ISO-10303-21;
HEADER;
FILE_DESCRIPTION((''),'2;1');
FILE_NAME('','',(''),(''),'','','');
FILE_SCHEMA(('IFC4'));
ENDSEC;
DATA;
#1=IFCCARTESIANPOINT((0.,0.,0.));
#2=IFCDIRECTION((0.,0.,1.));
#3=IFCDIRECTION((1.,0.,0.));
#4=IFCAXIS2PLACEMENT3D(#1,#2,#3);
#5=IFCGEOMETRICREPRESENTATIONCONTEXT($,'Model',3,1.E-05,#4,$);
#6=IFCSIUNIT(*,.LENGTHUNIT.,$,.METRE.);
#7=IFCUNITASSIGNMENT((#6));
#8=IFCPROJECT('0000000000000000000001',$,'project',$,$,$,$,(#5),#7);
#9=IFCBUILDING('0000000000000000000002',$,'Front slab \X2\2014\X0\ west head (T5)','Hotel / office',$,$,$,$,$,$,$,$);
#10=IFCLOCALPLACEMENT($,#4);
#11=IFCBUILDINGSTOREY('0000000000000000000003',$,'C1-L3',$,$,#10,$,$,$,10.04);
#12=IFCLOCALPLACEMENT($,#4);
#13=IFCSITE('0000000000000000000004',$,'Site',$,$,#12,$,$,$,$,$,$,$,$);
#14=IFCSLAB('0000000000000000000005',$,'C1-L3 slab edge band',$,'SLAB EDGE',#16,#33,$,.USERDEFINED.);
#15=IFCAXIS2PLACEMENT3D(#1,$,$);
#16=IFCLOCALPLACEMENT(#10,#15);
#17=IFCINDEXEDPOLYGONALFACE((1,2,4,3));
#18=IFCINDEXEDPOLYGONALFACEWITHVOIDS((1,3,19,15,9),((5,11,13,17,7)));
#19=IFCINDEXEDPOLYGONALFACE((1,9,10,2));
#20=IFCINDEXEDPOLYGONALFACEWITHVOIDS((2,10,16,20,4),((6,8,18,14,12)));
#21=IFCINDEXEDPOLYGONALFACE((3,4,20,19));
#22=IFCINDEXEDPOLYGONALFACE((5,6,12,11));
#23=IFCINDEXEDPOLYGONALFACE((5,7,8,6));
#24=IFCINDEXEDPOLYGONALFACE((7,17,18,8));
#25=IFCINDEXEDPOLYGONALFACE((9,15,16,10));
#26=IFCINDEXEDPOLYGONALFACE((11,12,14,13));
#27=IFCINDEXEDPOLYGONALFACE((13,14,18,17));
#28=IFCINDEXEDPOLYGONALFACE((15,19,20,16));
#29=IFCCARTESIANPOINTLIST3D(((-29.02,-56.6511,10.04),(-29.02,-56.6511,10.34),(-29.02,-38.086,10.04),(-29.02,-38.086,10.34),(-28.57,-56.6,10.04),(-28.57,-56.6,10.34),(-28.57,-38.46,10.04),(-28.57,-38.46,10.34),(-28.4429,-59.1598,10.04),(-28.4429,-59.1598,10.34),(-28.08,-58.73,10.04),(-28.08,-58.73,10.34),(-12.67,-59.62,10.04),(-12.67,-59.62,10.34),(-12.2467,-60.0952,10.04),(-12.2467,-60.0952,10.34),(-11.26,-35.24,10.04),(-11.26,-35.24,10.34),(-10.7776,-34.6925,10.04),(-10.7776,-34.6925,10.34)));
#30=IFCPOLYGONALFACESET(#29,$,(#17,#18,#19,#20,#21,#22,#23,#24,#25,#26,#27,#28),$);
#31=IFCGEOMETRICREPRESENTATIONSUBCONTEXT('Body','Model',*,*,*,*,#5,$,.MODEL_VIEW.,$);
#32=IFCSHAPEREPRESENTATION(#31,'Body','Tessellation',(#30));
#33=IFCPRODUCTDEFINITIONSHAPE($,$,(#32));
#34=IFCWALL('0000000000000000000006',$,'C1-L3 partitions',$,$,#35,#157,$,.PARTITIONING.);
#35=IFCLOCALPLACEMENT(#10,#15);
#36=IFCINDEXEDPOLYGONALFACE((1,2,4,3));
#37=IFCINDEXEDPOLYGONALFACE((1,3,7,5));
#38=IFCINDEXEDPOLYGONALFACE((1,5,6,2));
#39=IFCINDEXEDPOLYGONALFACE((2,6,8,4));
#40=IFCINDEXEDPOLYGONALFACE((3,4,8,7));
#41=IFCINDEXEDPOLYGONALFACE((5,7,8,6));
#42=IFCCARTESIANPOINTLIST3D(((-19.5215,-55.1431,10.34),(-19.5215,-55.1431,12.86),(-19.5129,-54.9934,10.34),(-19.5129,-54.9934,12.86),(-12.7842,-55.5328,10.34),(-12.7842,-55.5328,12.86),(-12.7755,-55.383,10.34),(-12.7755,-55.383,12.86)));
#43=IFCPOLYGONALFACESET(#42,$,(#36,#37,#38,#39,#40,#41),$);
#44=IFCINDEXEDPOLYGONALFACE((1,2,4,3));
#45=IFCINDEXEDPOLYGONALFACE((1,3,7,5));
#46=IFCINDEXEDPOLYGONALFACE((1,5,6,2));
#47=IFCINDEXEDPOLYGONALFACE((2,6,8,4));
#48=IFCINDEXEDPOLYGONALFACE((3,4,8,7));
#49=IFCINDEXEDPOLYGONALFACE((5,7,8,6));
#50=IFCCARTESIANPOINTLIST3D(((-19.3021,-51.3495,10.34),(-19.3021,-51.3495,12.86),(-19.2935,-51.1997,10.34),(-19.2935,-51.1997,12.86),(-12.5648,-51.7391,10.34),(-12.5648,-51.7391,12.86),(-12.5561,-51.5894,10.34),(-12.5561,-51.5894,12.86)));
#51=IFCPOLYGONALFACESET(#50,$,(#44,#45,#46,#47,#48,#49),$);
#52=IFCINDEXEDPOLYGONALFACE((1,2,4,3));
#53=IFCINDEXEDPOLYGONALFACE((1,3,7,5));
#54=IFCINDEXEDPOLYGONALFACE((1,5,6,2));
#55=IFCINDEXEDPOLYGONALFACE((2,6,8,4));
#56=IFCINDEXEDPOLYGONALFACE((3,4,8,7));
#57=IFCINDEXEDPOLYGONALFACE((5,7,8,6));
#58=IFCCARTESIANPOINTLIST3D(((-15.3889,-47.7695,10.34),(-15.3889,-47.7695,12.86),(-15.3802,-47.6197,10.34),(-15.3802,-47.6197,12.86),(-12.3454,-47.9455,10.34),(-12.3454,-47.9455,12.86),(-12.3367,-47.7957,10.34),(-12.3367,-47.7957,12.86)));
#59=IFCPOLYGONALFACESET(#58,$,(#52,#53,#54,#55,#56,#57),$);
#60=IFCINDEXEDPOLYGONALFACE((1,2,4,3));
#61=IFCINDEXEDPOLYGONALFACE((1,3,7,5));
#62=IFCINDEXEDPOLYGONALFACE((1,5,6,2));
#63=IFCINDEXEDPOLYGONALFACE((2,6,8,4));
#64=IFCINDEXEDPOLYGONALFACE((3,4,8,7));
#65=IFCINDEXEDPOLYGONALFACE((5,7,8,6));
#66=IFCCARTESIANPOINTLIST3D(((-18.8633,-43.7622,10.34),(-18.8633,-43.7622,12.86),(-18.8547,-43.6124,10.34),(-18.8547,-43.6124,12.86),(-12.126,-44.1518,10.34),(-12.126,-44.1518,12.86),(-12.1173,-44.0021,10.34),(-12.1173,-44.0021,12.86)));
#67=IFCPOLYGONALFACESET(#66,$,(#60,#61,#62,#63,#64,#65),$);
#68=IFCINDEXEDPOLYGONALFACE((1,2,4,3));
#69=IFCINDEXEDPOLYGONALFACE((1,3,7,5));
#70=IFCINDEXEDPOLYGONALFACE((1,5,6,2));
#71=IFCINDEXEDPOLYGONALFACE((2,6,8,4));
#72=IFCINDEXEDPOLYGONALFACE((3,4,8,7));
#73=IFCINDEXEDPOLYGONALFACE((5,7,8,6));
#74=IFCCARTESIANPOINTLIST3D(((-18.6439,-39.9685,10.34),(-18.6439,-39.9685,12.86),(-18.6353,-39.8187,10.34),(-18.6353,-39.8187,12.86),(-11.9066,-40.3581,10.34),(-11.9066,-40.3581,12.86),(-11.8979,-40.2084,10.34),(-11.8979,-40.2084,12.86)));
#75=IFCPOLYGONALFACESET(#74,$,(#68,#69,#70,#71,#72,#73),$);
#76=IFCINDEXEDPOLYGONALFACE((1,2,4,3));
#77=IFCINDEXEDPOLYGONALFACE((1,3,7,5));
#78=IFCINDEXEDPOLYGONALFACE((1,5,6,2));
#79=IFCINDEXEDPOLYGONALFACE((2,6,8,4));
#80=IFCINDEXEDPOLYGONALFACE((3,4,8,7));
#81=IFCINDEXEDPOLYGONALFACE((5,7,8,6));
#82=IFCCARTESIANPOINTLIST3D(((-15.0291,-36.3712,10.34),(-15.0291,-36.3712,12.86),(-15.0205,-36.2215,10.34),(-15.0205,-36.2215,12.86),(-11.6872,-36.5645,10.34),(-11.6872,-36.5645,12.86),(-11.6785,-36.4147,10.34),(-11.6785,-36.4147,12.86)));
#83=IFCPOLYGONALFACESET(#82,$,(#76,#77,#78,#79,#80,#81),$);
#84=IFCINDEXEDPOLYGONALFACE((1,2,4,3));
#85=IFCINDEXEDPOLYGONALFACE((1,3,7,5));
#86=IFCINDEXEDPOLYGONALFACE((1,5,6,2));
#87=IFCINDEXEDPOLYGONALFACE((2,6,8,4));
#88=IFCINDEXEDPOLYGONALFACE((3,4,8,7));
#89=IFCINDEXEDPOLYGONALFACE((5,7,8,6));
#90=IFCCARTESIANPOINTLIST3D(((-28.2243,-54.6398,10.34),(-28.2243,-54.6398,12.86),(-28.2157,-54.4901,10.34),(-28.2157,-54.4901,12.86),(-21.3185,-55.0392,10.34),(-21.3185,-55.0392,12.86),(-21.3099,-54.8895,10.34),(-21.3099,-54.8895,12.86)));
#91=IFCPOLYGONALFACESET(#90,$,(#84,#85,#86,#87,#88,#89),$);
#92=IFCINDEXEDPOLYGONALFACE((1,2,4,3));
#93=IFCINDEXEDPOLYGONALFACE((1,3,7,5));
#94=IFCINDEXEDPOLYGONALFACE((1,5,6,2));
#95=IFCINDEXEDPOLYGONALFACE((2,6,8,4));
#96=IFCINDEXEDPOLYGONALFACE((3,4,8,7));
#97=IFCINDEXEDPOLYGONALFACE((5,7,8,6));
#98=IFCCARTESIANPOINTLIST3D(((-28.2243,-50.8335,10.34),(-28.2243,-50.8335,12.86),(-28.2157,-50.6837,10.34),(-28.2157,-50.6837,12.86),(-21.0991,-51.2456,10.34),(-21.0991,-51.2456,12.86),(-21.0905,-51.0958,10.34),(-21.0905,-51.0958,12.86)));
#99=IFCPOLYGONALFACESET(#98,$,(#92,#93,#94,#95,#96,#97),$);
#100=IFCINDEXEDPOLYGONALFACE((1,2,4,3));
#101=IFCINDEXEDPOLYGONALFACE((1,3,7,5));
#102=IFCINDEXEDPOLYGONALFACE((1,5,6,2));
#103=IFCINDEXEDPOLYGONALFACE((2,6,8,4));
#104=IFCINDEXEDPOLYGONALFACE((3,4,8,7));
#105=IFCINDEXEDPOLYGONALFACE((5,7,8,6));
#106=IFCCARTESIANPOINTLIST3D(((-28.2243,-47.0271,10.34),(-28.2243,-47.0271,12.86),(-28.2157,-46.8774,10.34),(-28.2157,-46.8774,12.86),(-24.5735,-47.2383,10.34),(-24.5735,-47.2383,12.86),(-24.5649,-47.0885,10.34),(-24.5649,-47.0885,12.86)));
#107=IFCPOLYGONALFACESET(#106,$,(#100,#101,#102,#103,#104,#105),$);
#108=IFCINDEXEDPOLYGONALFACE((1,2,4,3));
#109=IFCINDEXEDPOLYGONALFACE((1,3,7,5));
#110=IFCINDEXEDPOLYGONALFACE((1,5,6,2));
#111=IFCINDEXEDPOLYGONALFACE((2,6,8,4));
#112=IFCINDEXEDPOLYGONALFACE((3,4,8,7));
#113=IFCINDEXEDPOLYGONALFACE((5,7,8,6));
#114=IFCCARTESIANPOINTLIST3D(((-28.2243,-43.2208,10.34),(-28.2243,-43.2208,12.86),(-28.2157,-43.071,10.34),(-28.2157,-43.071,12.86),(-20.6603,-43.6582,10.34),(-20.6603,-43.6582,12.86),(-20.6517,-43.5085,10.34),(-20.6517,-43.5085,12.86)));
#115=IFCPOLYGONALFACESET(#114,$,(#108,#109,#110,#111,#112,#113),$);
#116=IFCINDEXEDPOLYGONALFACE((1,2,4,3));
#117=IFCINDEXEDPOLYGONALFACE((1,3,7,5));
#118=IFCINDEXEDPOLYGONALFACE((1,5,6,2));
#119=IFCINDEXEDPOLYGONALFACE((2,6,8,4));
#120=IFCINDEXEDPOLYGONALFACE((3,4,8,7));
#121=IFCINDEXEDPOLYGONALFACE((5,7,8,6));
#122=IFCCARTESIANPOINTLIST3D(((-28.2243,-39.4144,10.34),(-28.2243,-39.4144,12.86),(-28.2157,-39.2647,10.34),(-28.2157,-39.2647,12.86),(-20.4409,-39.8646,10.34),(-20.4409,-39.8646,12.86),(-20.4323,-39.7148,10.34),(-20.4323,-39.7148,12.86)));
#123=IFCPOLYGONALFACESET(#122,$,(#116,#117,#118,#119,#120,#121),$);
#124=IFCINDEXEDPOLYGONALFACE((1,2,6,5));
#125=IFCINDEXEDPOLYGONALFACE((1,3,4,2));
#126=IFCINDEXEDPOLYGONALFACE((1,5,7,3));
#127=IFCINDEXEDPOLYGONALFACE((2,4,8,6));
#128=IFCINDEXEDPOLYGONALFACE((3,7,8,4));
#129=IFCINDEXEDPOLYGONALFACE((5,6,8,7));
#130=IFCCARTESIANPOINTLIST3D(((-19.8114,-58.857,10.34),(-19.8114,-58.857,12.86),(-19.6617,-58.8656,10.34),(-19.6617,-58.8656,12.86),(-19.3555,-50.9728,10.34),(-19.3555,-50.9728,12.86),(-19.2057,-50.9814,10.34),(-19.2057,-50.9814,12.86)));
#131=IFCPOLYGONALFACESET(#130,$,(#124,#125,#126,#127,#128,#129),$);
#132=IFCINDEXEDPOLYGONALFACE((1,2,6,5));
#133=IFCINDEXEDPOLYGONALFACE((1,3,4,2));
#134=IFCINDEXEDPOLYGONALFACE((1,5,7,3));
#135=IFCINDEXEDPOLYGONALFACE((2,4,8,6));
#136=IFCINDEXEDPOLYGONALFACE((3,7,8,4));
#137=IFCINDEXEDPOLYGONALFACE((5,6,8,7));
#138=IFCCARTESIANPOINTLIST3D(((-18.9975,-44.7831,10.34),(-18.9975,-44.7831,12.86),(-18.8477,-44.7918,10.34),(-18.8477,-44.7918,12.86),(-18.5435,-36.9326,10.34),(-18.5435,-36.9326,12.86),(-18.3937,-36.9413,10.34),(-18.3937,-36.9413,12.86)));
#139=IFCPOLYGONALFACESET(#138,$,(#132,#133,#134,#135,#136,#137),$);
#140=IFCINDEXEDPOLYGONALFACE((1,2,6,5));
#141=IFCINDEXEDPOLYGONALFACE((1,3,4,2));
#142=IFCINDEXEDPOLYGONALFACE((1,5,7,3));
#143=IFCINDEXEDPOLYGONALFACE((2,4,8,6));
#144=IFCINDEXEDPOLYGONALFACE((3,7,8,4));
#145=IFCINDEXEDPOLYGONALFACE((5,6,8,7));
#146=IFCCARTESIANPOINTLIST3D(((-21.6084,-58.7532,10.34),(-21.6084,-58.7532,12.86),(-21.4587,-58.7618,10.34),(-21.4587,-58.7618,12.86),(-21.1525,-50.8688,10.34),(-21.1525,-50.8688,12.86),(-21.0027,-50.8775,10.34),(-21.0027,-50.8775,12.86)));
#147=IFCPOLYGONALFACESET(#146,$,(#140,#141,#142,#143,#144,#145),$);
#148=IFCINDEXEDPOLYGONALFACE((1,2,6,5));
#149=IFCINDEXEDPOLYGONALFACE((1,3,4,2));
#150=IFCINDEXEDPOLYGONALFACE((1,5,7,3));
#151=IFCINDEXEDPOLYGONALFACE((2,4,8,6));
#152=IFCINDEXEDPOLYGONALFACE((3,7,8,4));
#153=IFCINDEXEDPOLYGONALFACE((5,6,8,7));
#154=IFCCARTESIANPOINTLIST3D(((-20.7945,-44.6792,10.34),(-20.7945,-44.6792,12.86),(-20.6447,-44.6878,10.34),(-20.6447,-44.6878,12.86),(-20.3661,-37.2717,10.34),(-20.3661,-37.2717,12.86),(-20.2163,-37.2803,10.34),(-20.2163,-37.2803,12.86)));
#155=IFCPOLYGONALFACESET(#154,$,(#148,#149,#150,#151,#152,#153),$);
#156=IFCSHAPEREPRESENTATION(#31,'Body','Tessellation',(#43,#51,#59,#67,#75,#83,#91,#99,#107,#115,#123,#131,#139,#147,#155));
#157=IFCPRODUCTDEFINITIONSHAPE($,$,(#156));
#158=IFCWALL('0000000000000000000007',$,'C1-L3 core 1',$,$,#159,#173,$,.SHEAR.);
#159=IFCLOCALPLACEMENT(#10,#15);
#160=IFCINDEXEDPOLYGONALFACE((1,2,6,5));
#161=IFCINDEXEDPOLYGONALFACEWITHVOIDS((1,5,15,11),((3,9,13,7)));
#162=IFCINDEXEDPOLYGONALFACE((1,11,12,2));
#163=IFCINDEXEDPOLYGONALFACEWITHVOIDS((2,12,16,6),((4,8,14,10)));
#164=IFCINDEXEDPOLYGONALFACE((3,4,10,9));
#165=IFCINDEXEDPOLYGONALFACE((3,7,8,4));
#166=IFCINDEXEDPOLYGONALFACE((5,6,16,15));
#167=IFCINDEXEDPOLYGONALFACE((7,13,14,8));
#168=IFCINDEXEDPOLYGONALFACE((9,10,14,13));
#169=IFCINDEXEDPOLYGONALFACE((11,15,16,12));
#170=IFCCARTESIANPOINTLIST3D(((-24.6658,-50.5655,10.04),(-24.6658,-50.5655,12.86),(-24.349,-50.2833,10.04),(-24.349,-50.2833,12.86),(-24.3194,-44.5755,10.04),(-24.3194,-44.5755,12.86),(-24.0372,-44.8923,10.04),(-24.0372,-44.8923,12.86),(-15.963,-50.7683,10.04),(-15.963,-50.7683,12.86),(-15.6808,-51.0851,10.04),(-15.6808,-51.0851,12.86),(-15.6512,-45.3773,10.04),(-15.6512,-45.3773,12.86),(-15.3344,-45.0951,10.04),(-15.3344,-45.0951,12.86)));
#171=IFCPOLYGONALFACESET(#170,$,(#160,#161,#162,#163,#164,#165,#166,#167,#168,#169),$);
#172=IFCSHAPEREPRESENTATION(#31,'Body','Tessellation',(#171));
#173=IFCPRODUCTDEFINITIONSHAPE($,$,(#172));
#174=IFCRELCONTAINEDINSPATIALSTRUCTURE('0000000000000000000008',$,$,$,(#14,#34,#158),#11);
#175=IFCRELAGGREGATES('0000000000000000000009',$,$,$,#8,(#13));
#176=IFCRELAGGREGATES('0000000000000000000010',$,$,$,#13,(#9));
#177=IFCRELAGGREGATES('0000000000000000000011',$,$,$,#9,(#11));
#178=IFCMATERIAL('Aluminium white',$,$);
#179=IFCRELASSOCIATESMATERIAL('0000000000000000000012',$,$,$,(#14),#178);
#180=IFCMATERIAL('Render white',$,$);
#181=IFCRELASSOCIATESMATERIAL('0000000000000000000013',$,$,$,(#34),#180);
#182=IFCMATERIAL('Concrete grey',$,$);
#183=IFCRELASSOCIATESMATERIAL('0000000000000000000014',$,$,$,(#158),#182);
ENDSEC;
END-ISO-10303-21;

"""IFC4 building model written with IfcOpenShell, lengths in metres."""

from ifc_helpers import new_model, si_unit, frame, origin_with_axes, place, context, subcontext, project, spatial, polyline, outline, extrude, material, element, save


model = new_model("IFC4")

# Units and contexts
model_context = context("Model", 3, precision=1e-05, world=origin_with_axes())
body_context = subcontext(model_context, "Body", "Model", "MODEL_VIEW")
ifc_project = project(units=[si_unit("LENGTHUNIT", "METRE")], contexts=[model_context])

# Site, building, storey
site_placement = place(None, origin_with_axes())
site = spatial("IfcSite", under=ifc_project, at=site_placement, Name="Site")
building = spatial("IfcBuilding", under=site, Name="Front slab — west head (T5)", Description="Hotel / office")
storey_placement = place(None, origin_with_axes())
storey = spatial("IfcBuildingStorey", under=building, at=storey_placement, Name="C1-L3", Elevation=10.04)

# Shared definitions
ifc_material_1 = material(Name="Aluminium white")

# Slab
slab_placement = place(storey_placement, origin_with_axes())
element("IfcSlab", 1, at=slab_placement, inside=storey, material=ifc_material_1, Name="C1-L3 slab edge band", ObjectType="SLAB EDGE", PredefinedType="USERDEFINED", context=body_context, shape_type="SweptSolid", body=[
    extrude(outline(polyline([(-10.7776, -34.6925), (-29.02, -38.086), (-29.02, -56.6511), (-28.4429, -59.1598), (-12.2467, -60.0952), (-10.7776, -34.6925)]), holes=[polyline([(-11.26, -35.24), (-28.57, -38.46), (-28.57, -56.6), (-28.08, -58.73), (-12.67, -59.62), (-11.26, -35.24)])]), frame((0.0, 0.0, 10.04), z_axis=(0.0, 0.0, 1.0), x_axis=(1.0, 0.0, 0.0)), (0.0, 0.0, 1.0), 0.3),
])

# Walls
ifc_material_2 = material(Name="Render white")
wall_1_placement = place(storey_placement, origin_with_axes())
element("IfcWall", 2, at=wall_1_placement, inside=storey, material=ifc_material_2, Name="C1-L3 partitions", PredefinedType="PARTITIONING", context=body_context, shape_type="SweptSolid", body=[
    extrude(outline(polyline([(-12.7755, -55.383), (-19.5129, -54.9934), (-19.5215, -55.1431), (-12.7842, -55.5328), (-12.7755, -55.383)])), frame((0.0, 0.0, 10.34), z_axis=(0.0, 0.0, 1.0), x_axis=(1.0, 0.0, 0.0)), (0.0, 0.0, 1.0), 2.52),
    extrude(outline(polyline([(-12.5561, -51.5894), (-19.2935, -51.1997), (-19.3021, -51.3495), (-12.5648, -51.7391), (-12.5561, -51.5894)])), frame((0.0, 0.0, 10.34), z_axis=(0.0, 0.0, 1.0), x_axis=(1.0, 0.0, 0.0)), (0.0, 0.0, 1.0), 2.52),
    extrude(outline(polyline([(-12.3367, -47.7957), (-15.3802, -47.6197), (-15.3889, -47.7695), (-12.3454, -47.9455), (-12.3367, -47.7957)])), frame((0.0, 0.0, 10.34), z_axis=(0.0, 0.0, 1.0), x_axis=(1.0, 0.0, 0.0)), (0.0, 0.0, 1.0), 2.52),
    extrude(outline(polyline([(-12.1173, -44.0021), (-18.8547, -43.6124), (-18.8633, -43.7622), (-12.126, -44.1518), (-12.1173, -44.0021)])), frame((0.0, 0.0, 10.34), z_axis=(0.0, 0.0, 1.0), x_axis=(1.0, 0.0, 0.0)), (0.0, 0.0, 1.0), 2.52),
    extrude(outline(polyline([(-11.8979, -40.2084), (-18.6353, -39.8187), (-18.6439, -39.9685), (-11.9066, -40.3581), (-11.8979, -40.2084)])), frame((0.0, 0.0, 10.34), z_axis=(0.0, 0.0, 1.0), x_axis=(1.0, 0.0, 0.0)), (0.0, 0.0, 1.0), 2.52),
    extrude(outline(polyline([(-11.6785, -36.4147), (-15.0205, -36.2215), (-15.0291, -36.3712), (-11.6872, -36.5645), (-11.6785, -36.4147)])), frame((0.0, 0.0, 10.34), z_axis=(0.0, 0.0, 1.0), x_axis=(1.0, 0.0, 0.0)), (0.0, 0.0, 1.0), 2.52),
    extrude(outline(polyline([(-21.3099, -54.8895), (-28.2157, -54.4901), (-28.2243, -54.6398), (-21.3185, -55.0392), (-21.3099, -54.8895)])), frame((0.0, 0.0, 10.34), z_axis=(0.0, 0.0, 1.0), x_axis=(1.0, 0.0, 0.0)), (0.0, 0.0, 1.0), 2.52),
    extrude(outline(polyline([(-21.0905, -51.0958), (-28.2157, -50.6837), (-28.2243, -50.8335), (-21.0991, -51.2456), (-21.0905, -51.0958)])), frame((0.0, 0.0, 10.34), z_axis=(0.0, 0.0, 1.0), x_axis=(1.0, 0.0, 0.0)), (0.0, 0.0, 1.0), 2.52),
    extrude(outline(polyline([(-24.5649, -47.0885), (-28.2157, -46.8774), (-28.2243, -47.0271), (-24.5735, -47.2383), (-24.5649, -47.0885)])), frame((0.0, 0.0, 10.34), z_axis=(0.0, 0.0, 1.0), x_axis=(1.0, 0.0, 0.0)), (0.0, 0.0, 1.0), 2.52),
    extrude(outline(polyline([(-20.6517, -43.5085), (-28.2157, -43.071), (-28.2243, -43.2208), (-20.6603, -43.6582), (-20.6517, -43.5085)])), frame((0.0, 0.0, 10.34), z_axis=(0.0, 0.0, 1.0), x_axis=(1.0, 0.0, 0.0)), (0.0, 0.0, 1.0), 2.52),
    extrude(outline(polyline([(-20.4323, -39.7148), (-28.2157, -39.2647), (-28.2243, -39.4144), (-20.4409, -39.8646), (-20.4323, -39.7148)])), frame((0.0, 0.0, 10.34), z_axis=(0.0, 0.0, 1.0), x_axis=(1.0, 0.0, 0.0)), (0.0, 0.0, 1.0), 2.52),
    extrude(outline(polyline([(-19.6617, -58.8656), (-19.2057, -50.9814), (-19.3555, -50.9728), (-19.8114, -58.857), (-19.6617, -58.8656)])), frame((0.0, 0.0, 10.34), z_axis=(0.0, 0.0, 1.0), x_axis=(1.0, 0.0, 0.0)), (0.0, 0.0, 1.0), 2.52),
    extrude(outline(polyline([(-18.8477, -44.7918), (-18.3937, -36.9413), (-18.5435, -36.9326), (-18.9975, -44.7831), (-18.8477, -44.7918)])), frame((0.0, 0.0, 10.34), z_axis=(0.0, 0.0, 1.0), x_axis=(1.0, 0.0, 0.0)), (0.0, 0.0, 1.0), 2.52),
    extrude(outline(polyline([(-21.4587, -58.7618), (-21.0027, -50.8775), (-21.1525, -50.8688), (-21.6084, -58.7532), (-21.4587, -58.7618)])), frame((0.0, 0.0, 10.34), z_axis=(0.0, 0.0, 1.0), x_axis=(1.0, 0.0, 0.0)), (0.0, 0.0, 1.0), 2.52),
    extrude(outline(polyline([(-20.6447, -44.6878), (-20.2163, -37.2803), (-20.3661, -37.2717), (-20.7945, -44.6792), (-20.6447, -44.6878)])), frame((0.0, 0.0, 10.34), z_axis=(0.0, 0.0, 1.0), x_axis=(1.0, 0.0, 0.0)), (0.0, 0.0, 1.0), 2.52),
])
ifc_material_3 = material(Name="Concrete grey")
wall_2_placement = place(storey_placement, origin_with_axes())
element("IfcWall", 3, at=wall_2_placement, inside=storey, material=ifc_material_3, Name="C1-L3 core 1", PredefinedType="SHEAR", context=body_context, shape_type="SweptSolid", body=[
    extrude(outline(polyline([(-15.6808, -51.0851), (-15.3344, -45.0951), (-24.3194, -44.5755), (-24.6658, -50.5655), (-15.6808, -51.0851)]), holes=[polyline([(-15.963, -50.7683), (-15.6512, -45.3773), (-24.0372, -44.8923), (-24.349, -50.2833), (-15.963, -50.7683)])]), frame((0.0, 0.0, 10.04), z_axis=(0.0, 0.0, 1.0), x_axis=(1.0, 0.0, 0.0)), (0.0, 0.0, 1.0), 2.82),
])

save(model, "model.ifc")
